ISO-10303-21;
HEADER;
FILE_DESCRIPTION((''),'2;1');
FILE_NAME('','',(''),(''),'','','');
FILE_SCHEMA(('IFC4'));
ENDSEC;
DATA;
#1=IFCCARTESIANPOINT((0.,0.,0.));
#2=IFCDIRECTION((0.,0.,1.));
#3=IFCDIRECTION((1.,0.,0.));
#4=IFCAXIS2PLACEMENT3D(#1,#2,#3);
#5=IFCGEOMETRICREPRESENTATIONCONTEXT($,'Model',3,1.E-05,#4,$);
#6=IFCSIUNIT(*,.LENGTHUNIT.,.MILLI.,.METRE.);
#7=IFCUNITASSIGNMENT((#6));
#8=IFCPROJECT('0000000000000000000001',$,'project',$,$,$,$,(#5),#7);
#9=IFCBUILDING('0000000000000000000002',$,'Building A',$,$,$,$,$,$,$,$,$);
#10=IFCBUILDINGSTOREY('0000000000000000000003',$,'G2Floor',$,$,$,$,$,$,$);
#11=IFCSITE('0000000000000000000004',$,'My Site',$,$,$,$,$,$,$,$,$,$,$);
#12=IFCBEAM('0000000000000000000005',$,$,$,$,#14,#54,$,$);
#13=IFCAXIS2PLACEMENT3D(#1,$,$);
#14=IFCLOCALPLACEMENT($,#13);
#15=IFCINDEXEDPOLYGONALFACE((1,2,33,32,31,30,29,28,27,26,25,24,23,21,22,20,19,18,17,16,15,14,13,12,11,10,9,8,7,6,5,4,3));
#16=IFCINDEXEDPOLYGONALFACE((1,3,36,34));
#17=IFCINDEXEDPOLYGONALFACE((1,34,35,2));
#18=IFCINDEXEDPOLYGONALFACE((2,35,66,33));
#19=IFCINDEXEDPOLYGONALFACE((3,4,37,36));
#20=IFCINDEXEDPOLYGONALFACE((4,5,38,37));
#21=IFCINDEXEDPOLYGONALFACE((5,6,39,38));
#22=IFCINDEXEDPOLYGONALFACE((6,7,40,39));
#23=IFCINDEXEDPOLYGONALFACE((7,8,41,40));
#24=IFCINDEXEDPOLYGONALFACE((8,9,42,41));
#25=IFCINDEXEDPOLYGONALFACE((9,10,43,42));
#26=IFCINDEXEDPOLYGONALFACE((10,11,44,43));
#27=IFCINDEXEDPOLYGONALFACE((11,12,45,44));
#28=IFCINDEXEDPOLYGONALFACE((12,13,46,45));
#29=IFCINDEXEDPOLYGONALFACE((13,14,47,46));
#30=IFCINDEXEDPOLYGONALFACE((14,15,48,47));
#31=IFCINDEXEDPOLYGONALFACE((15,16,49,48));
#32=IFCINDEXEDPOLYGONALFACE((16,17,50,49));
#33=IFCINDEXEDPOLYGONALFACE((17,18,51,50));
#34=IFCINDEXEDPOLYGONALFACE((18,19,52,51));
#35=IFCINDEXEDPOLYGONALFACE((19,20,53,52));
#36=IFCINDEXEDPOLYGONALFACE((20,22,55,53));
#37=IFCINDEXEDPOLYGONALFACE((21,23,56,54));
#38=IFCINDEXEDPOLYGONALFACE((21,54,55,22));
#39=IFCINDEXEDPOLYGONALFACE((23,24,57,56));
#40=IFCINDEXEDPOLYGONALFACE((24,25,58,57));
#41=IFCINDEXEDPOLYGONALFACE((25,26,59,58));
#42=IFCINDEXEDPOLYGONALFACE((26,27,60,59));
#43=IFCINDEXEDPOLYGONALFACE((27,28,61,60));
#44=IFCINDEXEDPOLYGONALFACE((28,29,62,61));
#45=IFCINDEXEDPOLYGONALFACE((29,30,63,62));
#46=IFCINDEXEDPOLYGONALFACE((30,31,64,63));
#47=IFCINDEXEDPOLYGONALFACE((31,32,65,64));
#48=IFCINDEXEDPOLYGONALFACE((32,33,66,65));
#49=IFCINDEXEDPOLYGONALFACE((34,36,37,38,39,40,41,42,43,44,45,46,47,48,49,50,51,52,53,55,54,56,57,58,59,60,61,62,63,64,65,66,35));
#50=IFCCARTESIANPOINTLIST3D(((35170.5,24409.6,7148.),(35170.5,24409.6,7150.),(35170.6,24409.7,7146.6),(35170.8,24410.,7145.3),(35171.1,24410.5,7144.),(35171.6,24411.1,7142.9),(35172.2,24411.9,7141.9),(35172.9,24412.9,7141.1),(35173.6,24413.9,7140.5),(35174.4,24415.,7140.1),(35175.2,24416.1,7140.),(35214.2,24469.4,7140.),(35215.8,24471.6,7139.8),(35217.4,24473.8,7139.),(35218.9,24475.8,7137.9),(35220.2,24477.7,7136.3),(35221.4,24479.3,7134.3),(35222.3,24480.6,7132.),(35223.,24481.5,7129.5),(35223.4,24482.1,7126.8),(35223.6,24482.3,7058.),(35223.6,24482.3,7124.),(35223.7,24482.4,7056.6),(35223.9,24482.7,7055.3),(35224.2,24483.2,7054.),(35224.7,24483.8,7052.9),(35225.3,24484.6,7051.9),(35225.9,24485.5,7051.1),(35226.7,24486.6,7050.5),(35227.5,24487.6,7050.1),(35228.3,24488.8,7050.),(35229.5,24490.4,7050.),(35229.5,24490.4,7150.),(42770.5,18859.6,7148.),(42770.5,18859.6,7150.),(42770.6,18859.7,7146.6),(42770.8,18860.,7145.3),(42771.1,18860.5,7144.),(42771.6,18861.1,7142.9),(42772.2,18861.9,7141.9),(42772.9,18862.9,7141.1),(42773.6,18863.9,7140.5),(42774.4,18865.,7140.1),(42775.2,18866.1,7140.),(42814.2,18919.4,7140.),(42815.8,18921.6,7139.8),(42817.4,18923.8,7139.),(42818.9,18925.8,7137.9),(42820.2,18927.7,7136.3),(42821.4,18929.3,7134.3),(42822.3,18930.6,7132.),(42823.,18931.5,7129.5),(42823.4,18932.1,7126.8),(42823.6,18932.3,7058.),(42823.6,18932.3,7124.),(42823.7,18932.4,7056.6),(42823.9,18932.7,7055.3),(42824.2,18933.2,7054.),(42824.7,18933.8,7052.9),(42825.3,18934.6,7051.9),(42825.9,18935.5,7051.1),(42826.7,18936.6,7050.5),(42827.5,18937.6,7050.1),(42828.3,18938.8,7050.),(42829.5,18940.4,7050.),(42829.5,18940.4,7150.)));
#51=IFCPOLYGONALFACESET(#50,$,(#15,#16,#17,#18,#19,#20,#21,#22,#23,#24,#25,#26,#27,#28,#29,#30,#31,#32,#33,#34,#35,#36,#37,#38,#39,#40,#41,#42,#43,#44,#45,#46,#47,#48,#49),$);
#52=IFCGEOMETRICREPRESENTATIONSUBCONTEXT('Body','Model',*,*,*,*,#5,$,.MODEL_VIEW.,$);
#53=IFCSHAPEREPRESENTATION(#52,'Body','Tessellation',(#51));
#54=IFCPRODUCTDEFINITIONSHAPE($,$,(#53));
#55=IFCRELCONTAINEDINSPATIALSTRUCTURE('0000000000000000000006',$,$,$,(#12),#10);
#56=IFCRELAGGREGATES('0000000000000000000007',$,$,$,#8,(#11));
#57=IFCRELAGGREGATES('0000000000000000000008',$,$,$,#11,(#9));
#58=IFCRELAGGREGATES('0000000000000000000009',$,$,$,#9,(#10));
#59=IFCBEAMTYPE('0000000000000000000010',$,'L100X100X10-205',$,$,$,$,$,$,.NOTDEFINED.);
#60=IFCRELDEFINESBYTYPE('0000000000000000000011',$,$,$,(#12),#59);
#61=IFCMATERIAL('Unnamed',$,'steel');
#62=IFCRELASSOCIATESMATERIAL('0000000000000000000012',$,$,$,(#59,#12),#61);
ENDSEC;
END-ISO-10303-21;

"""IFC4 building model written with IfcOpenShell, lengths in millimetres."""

from ifc_helpers import new_model, si_unit, frame, origin_with_axes, place, context, subcontext, project, spatial, polyline, outline, extrude, material, material_profile, profile_set, profile_usage, type_object, element, save


model = new_model("IFC4")

# Units and contexts
model_context = context("Model", 3, precision=1e-05, world=origin_with_axes())
body_context = subcontext(model_context, "Body", "Model", "MODEL_VIEW")
ifc_project = project(units=[si_unit("LENGTHUNIT", "METRE", prefix="MILLI")], contexts=[model_context])

# Site, building, storey
site = spatial("IfcSite", under=ifc_project, Name="My Site")
building = spatial("IfcBuilding", under=site, Name="Building A")
storey = spatial("IfcBuildingStorey", under=building, Name="G2Floor")

# Beam
ifc_material_1 = material(Name="Unnamed", Category="steel")
ifc_material_profile_1 = material_profile(ifc_material_1, outline(polyline([(-50.0, -50.0), (50.0, -50.0), (50.0, -50.0), (50.0, -48.0), (50.0, -48.0), (49.9, -46.6), (49.9, -46.6), (49.5, -45.3), (49.5, -45.3), (48.9, -44.0), (48.9, -44.0), (48.1, -42.9), (48.1, -42.9), (47.1, -41.9), (47.1, -41.9), (46.0, -41.1), (46.0, -41.1), (44.7, -40.5), (44.7, -40.5), (43.4, -40.1), (43.4, -40.1), (42.0, -40.0), (42.0, -40.0), (-24.0, -40.0), (-24.0, -40.0), (-26.8, -39.8), (-26.8, -39.8), (-29.5, -39.0), (-29.5, -39.0), (-32.0, -37.9), (-32.0, -37.9), (-34.3, -36.3), (-34.3, -36.3), (-36.3, -34.3), (-36.3, -34.3), (-37.9, -32.0), (-37.9, -32.0), (-39.0, -29.5), (-39.0, -29.5), (-39.8, -26.8), (-39.8, -26.8), (-40.0, -24.0), (-40.0, -24.0), (-40.0, 42.0), (-40.0, 42.0), (-40.1, 43.4), (-40.1, 43.4), (-40.5, 44.7), (-40.5, 44.7), (-41.1, 46.0), (-41.1, 46.0), (-41.9, 47.1), (-41.9, 47.1), (-42.9, 48.1), (-42.9, 48.1), (-44.0, 48.9), (-44.0, 48.9), (-45.3, 49.5), (-45.3, 49.5), (-46.6, 49.9), (-46.6, 49.9), (-48.0, 50.0), (-48.0, 50.0), (-50.0, 50.0), (-50.0, 50.0), (-50.0, -50.0)])))
ifc_profile_set_1 = profile_set([ifc_material_profile_1], Name="L100X100X10-205")
ifc_profile_usage_1 = profile_usage(ifc_profile_set_1)
beam_type_1 = type_object("IfcBeamType", Name="L100X100X10-205", PredefinedType="NOTDEFINED", material=ifc_profile_set_1)
beam_1_placement = place(None, frame((35200.0, 24450.0, 7100.0), z_axis=(0.807586, -0.58975, 0.0), x_axis=(-0.58975, -0.807586, 0.0)))
element("IfcBeam", 1, at=beam_1_placement, inside=storey, type_object=beam_type_1, material=ifc_profile_usage_1, context=body_context, shape_type="SweptSolid", body=[
    extrude(outline(polyline([(-50.0, -50.0), (50.0, -50.0), (50.0, -50.0), (50.0, -48.0), (50.0, -48.0), (49.9, -46.6), (49.9, -46.6), (49.5, -45.3), (49.5, -45.3), (48.9, -44.0), (48.9, -44.0), (48.1, -42.9), (48.1, -42.9), (47.1, -41.9), (47.1, -41.9), (46.0, -41.1), (46.0, -41.1), (44.7, -40.5), (44.7, -40.5), (43.4, -40.1), (43.4, -40.1), (42.0, -40.0), (42.0, -40.0), (-24.0, -40.0), (-24.0, -40.0), (-26.8, -39.8), (-26.8, -39.8), (-29.5, -39.0), (-29.5, -39.0), (-32.0, -37.9), (-32.0, -37.9), (-34.3, -36.3), (-34.3, -36.3), (-36.3, -34.3), (-36.3, -34.3), (-37.9, -32.0), (-37.9, -32.0), (-39.0, -29.5), (-39.0, -29.5), (-39.8, -26.8), (-39.8, -26.8), (-40.0, -24.0), (-40.0, -24.0), (-40.0, 42.0), (-40.0, 42.0), (-40.1, 43.4), (-40.1, 43.4), (-40.5, 44.7), (-40.5, 44.7), (-41.1, 46.0), (-41.1, 46.0), (-41.9, 47.1), (-41.9, 47.1), (-42.9, 48.1), (-42.9, 48.1), (-44.0, 48.9), (-44.0, 48.9), (-45.3, 49.5), (-45.3, 49.5), (-46.6, 49.9), (-46.6, 49.9), (-48.0, 50.0), (-48.0, 50.0), (-50.0, 50.0), (-50.0, 50.0), (-50.0, -50.0)])), origin_with_axes(), (0.0, 0.0, 1.0), 9410.8),
])

save(model, "model.ifc")
